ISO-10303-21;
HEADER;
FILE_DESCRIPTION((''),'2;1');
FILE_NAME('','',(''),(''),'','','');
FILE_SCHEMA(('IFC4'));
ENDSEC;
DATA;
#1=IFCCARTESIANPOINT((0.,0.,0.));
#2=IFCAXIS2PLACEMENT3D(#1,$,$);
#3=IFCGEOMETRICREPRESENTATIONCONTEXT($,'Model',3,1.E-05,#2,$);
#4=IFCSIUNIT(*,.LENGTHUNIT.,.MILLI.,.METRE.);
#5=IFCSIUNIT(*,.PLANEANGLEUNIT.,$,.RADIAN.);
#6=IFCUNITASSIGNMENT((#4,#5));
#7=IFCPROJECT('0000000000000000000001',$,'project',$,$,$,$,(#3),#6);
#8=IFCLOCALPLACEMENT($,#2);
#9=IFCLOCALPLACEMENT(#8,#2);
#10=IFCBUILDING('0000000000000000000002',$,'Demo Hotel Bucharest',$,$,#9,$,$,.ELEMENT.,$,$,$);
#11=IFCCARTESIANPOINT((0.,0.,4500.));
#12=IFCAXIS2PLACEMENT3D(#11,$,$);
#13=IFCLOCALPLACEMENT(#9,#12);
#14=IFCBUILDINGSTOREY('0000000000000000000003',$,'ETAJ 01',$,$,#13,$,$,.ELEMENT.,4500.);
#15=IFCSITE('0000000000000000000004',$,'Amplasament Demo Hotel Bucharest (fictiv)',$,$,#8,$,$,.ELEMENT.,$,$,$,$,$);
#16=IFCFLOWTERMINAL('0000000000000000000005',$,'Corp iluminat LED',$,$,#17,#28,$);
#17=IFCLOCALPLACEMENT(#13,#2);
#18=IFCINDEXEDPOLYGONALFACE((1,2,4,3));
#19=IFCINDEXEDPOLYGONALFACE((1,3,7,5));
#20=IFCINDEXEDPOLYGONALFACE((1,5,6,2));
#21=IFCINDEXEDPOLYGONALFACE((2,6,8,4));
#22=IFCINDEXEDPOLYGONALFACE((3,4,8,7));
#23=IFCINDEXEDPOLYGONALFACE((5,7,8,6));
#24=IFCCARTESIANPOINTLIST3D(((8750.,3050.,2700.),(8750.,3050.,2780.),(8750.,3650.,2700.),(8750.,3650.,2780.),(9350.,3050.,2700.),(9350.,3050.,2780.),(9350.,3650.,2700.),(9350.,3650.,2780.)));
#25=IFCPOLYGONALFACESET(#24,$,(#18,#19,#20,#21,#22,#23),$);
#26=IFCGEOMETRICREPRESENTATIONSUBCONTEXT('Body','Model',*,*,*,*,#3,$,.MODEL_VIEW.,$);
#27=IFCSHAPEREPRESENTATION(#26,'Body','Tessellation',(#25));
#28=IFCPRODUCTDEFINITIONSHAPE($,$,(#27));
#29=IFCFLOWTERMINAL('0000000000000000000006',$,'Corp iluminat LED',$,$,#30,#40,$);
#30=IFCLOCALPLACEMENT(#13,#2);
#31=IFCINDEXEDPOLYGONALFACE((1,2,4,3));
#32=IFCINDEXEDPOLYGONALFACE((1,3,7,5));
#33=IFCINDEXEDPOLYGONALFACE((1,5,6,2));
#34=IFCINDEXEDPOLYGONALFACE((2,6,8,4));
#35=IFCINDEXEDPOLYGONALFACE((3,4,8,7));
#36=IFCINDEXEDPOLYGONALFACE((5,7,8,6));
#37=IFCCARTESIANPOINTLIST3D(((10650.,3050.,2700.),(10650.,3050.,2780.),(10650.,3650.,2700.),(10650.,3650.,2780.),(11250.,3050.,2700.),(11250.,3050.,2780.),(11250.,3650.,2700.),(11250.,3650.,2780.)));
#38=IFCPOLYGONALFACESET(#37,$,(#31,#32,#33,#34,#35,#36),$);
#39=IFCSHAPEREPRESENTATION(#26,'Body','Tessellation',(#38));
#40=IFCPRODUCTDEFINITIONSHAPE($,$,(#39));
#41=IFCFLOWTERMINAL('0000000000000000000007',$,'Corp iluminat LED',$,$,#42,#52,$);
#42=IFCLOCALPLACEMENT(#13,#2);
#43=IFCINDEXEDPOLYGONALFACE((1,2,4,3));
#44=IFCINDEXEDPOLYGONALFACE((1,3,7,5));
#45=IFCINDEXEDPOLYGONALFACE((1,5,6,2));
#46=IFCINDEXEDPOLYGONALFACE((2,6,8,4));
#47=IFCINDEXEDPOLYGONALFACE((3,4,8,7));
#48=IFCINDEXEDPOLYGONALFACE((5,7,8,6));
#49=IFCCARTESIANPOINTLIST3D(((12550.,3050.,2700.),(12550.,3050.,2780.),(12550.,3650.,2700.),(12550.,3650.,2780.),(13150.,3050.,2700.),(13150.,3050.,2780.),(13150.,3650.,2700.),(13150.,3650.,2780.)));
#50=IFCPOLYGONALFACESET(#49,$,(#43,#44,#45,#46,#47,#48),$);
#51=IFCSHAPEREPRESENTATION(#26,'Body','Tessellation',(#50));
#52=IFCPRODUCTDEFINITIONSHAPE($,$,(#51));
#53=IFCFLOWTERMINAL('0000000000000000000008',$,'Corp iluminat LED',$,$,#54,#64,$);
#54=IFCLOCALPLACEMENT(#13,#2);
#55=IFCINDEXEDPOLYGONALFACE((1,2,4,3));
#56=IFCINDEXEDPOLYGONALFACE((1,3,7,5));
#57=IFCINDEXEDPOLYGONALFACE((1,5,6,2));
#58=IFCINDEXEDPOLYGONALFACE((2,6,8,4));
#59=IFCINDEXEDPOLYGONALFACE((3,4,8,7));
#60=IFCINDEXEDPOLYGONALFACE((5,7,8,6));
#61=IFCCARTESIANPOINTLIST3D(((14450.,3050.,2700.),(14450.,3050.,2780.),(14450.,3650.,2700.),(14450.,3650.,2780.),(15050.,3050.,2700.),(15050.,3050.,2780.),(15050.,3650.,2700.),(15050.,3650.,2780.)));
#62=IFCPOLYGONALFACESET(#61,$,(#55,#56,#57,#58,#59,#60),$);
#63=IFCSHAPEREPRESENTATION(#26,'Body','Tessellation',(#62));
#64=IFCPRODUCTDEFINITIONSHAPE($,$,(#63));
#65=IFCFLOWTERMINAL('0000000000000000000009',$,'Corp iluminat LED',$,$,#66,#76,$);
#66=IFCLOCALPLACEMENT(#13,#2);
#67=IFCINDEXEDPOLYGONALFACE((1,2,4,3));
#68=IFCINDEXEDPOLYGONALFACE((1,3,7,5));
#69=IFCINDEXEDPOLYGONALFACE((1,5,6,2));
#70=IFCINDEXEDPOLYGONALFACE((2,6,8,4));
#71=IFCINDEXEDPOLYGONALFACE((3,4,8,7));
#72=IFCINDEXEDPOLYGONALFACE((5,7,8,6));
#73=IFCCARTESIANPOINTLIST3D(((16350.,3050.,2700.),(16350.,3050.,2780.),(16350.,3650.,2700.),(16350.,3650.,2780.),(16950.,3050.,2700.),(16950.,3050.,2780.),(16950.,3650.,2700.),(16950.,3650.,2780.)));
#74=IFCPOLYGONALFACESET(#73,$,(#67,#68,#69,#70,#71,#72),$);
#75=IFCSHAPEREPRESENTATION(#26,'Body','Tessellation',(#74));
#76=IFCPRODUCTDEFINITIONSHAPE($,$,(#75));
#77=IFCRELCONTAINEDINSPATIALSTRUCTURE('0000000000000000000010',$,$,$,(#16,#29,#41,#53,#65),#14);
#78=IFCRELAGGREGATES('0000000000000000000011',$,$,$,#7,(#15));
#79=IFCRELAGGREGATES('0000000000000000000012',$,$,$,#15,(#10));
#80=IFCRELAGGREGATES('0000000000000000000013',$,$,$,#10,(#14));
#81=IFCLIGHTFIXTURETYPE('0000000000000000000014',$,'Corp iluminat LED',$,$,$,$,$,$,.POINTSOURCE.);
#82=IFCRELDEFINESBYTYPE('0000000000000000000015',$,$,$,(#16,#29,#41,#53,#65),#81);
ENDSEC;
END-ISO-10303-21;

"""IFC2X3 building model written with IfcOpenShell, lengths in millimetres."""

from ifc_helpers import new_model, si_unit, frame, frame_2d, origin, place, context, subcontext, project, spatial, rectangle, extrude, type_object, element, save


model = new_model("IFC2X3")

# Units and contexts
model_context = context("Model", 3, precision=1e-05, world=origin())
body_context = subcontext(model_context, "Body", "Model", "MODEL_VIEW")
ifc_project = project(units=[si_unit("LENGTHUNIT", "METRE", prefix="MILLI"), si_unit("PLANEANGLEUNIT", "RADIAN")], contexts=[model_context])

# Site, building, storey
site_placement = place(None, origin())
site = spatial("IfcSite", under=ifc_project, at=site_placement, Name="Amplasament Demo Hotel Bucharest (fictiv)", CompositionType="ELEMENT")
building_placement = place(site_placement, origin())
building = spatial("IfcBuilding", under=site, at=building_placement, Name="Demo Hotel Bucharest", CompositionType="ELEMENT")
storey_placement = place(building_placement, frame((0.0, 0.0, 4500.0)))
storey = spatial("IfcBuildingStorey", under=building, at=storey_placement, Name="ETAJ 01", CompositionType="ELEMENT", Elevation=4500.0)

# Flow terminals
light_fixture_type = type_object("IfcLightFixtureType", Name="Corp iluminat LED", PredefinedType="POINTSOURCE")
for number, where, name in (
    (1, (8750.0, 3050.0, 2700.0), "Corp iluminat LED"),
    (2, (10650.0, 3050.0, 2700.0), "Corp iluminat LED"),
    (3, (12550.0, 3050.0, 2700.0), "Corp iluminat LED"),
    (4, (14450.0, 3050.0, 2700.0), "Corp iluminat LED"),
    (5, (16350.0, 3050.0, 2700.0), "Corp iluminat LED"),
):
    element("IfcFlowTerminal", number, at=place(storey_placement, frame(where)), inside=storey, type_object=light_fixture_type, Name=name, context=body_context, shape_type="SweptSolid", body=[
        extrude(rectangle(XDim=600.0, YDim=600.0, at=frame_2d((300.0, 300.0))), origin(), (0.0, 0.0, 1.0), 80.0),
    ])

save(model, "model.ifc")
